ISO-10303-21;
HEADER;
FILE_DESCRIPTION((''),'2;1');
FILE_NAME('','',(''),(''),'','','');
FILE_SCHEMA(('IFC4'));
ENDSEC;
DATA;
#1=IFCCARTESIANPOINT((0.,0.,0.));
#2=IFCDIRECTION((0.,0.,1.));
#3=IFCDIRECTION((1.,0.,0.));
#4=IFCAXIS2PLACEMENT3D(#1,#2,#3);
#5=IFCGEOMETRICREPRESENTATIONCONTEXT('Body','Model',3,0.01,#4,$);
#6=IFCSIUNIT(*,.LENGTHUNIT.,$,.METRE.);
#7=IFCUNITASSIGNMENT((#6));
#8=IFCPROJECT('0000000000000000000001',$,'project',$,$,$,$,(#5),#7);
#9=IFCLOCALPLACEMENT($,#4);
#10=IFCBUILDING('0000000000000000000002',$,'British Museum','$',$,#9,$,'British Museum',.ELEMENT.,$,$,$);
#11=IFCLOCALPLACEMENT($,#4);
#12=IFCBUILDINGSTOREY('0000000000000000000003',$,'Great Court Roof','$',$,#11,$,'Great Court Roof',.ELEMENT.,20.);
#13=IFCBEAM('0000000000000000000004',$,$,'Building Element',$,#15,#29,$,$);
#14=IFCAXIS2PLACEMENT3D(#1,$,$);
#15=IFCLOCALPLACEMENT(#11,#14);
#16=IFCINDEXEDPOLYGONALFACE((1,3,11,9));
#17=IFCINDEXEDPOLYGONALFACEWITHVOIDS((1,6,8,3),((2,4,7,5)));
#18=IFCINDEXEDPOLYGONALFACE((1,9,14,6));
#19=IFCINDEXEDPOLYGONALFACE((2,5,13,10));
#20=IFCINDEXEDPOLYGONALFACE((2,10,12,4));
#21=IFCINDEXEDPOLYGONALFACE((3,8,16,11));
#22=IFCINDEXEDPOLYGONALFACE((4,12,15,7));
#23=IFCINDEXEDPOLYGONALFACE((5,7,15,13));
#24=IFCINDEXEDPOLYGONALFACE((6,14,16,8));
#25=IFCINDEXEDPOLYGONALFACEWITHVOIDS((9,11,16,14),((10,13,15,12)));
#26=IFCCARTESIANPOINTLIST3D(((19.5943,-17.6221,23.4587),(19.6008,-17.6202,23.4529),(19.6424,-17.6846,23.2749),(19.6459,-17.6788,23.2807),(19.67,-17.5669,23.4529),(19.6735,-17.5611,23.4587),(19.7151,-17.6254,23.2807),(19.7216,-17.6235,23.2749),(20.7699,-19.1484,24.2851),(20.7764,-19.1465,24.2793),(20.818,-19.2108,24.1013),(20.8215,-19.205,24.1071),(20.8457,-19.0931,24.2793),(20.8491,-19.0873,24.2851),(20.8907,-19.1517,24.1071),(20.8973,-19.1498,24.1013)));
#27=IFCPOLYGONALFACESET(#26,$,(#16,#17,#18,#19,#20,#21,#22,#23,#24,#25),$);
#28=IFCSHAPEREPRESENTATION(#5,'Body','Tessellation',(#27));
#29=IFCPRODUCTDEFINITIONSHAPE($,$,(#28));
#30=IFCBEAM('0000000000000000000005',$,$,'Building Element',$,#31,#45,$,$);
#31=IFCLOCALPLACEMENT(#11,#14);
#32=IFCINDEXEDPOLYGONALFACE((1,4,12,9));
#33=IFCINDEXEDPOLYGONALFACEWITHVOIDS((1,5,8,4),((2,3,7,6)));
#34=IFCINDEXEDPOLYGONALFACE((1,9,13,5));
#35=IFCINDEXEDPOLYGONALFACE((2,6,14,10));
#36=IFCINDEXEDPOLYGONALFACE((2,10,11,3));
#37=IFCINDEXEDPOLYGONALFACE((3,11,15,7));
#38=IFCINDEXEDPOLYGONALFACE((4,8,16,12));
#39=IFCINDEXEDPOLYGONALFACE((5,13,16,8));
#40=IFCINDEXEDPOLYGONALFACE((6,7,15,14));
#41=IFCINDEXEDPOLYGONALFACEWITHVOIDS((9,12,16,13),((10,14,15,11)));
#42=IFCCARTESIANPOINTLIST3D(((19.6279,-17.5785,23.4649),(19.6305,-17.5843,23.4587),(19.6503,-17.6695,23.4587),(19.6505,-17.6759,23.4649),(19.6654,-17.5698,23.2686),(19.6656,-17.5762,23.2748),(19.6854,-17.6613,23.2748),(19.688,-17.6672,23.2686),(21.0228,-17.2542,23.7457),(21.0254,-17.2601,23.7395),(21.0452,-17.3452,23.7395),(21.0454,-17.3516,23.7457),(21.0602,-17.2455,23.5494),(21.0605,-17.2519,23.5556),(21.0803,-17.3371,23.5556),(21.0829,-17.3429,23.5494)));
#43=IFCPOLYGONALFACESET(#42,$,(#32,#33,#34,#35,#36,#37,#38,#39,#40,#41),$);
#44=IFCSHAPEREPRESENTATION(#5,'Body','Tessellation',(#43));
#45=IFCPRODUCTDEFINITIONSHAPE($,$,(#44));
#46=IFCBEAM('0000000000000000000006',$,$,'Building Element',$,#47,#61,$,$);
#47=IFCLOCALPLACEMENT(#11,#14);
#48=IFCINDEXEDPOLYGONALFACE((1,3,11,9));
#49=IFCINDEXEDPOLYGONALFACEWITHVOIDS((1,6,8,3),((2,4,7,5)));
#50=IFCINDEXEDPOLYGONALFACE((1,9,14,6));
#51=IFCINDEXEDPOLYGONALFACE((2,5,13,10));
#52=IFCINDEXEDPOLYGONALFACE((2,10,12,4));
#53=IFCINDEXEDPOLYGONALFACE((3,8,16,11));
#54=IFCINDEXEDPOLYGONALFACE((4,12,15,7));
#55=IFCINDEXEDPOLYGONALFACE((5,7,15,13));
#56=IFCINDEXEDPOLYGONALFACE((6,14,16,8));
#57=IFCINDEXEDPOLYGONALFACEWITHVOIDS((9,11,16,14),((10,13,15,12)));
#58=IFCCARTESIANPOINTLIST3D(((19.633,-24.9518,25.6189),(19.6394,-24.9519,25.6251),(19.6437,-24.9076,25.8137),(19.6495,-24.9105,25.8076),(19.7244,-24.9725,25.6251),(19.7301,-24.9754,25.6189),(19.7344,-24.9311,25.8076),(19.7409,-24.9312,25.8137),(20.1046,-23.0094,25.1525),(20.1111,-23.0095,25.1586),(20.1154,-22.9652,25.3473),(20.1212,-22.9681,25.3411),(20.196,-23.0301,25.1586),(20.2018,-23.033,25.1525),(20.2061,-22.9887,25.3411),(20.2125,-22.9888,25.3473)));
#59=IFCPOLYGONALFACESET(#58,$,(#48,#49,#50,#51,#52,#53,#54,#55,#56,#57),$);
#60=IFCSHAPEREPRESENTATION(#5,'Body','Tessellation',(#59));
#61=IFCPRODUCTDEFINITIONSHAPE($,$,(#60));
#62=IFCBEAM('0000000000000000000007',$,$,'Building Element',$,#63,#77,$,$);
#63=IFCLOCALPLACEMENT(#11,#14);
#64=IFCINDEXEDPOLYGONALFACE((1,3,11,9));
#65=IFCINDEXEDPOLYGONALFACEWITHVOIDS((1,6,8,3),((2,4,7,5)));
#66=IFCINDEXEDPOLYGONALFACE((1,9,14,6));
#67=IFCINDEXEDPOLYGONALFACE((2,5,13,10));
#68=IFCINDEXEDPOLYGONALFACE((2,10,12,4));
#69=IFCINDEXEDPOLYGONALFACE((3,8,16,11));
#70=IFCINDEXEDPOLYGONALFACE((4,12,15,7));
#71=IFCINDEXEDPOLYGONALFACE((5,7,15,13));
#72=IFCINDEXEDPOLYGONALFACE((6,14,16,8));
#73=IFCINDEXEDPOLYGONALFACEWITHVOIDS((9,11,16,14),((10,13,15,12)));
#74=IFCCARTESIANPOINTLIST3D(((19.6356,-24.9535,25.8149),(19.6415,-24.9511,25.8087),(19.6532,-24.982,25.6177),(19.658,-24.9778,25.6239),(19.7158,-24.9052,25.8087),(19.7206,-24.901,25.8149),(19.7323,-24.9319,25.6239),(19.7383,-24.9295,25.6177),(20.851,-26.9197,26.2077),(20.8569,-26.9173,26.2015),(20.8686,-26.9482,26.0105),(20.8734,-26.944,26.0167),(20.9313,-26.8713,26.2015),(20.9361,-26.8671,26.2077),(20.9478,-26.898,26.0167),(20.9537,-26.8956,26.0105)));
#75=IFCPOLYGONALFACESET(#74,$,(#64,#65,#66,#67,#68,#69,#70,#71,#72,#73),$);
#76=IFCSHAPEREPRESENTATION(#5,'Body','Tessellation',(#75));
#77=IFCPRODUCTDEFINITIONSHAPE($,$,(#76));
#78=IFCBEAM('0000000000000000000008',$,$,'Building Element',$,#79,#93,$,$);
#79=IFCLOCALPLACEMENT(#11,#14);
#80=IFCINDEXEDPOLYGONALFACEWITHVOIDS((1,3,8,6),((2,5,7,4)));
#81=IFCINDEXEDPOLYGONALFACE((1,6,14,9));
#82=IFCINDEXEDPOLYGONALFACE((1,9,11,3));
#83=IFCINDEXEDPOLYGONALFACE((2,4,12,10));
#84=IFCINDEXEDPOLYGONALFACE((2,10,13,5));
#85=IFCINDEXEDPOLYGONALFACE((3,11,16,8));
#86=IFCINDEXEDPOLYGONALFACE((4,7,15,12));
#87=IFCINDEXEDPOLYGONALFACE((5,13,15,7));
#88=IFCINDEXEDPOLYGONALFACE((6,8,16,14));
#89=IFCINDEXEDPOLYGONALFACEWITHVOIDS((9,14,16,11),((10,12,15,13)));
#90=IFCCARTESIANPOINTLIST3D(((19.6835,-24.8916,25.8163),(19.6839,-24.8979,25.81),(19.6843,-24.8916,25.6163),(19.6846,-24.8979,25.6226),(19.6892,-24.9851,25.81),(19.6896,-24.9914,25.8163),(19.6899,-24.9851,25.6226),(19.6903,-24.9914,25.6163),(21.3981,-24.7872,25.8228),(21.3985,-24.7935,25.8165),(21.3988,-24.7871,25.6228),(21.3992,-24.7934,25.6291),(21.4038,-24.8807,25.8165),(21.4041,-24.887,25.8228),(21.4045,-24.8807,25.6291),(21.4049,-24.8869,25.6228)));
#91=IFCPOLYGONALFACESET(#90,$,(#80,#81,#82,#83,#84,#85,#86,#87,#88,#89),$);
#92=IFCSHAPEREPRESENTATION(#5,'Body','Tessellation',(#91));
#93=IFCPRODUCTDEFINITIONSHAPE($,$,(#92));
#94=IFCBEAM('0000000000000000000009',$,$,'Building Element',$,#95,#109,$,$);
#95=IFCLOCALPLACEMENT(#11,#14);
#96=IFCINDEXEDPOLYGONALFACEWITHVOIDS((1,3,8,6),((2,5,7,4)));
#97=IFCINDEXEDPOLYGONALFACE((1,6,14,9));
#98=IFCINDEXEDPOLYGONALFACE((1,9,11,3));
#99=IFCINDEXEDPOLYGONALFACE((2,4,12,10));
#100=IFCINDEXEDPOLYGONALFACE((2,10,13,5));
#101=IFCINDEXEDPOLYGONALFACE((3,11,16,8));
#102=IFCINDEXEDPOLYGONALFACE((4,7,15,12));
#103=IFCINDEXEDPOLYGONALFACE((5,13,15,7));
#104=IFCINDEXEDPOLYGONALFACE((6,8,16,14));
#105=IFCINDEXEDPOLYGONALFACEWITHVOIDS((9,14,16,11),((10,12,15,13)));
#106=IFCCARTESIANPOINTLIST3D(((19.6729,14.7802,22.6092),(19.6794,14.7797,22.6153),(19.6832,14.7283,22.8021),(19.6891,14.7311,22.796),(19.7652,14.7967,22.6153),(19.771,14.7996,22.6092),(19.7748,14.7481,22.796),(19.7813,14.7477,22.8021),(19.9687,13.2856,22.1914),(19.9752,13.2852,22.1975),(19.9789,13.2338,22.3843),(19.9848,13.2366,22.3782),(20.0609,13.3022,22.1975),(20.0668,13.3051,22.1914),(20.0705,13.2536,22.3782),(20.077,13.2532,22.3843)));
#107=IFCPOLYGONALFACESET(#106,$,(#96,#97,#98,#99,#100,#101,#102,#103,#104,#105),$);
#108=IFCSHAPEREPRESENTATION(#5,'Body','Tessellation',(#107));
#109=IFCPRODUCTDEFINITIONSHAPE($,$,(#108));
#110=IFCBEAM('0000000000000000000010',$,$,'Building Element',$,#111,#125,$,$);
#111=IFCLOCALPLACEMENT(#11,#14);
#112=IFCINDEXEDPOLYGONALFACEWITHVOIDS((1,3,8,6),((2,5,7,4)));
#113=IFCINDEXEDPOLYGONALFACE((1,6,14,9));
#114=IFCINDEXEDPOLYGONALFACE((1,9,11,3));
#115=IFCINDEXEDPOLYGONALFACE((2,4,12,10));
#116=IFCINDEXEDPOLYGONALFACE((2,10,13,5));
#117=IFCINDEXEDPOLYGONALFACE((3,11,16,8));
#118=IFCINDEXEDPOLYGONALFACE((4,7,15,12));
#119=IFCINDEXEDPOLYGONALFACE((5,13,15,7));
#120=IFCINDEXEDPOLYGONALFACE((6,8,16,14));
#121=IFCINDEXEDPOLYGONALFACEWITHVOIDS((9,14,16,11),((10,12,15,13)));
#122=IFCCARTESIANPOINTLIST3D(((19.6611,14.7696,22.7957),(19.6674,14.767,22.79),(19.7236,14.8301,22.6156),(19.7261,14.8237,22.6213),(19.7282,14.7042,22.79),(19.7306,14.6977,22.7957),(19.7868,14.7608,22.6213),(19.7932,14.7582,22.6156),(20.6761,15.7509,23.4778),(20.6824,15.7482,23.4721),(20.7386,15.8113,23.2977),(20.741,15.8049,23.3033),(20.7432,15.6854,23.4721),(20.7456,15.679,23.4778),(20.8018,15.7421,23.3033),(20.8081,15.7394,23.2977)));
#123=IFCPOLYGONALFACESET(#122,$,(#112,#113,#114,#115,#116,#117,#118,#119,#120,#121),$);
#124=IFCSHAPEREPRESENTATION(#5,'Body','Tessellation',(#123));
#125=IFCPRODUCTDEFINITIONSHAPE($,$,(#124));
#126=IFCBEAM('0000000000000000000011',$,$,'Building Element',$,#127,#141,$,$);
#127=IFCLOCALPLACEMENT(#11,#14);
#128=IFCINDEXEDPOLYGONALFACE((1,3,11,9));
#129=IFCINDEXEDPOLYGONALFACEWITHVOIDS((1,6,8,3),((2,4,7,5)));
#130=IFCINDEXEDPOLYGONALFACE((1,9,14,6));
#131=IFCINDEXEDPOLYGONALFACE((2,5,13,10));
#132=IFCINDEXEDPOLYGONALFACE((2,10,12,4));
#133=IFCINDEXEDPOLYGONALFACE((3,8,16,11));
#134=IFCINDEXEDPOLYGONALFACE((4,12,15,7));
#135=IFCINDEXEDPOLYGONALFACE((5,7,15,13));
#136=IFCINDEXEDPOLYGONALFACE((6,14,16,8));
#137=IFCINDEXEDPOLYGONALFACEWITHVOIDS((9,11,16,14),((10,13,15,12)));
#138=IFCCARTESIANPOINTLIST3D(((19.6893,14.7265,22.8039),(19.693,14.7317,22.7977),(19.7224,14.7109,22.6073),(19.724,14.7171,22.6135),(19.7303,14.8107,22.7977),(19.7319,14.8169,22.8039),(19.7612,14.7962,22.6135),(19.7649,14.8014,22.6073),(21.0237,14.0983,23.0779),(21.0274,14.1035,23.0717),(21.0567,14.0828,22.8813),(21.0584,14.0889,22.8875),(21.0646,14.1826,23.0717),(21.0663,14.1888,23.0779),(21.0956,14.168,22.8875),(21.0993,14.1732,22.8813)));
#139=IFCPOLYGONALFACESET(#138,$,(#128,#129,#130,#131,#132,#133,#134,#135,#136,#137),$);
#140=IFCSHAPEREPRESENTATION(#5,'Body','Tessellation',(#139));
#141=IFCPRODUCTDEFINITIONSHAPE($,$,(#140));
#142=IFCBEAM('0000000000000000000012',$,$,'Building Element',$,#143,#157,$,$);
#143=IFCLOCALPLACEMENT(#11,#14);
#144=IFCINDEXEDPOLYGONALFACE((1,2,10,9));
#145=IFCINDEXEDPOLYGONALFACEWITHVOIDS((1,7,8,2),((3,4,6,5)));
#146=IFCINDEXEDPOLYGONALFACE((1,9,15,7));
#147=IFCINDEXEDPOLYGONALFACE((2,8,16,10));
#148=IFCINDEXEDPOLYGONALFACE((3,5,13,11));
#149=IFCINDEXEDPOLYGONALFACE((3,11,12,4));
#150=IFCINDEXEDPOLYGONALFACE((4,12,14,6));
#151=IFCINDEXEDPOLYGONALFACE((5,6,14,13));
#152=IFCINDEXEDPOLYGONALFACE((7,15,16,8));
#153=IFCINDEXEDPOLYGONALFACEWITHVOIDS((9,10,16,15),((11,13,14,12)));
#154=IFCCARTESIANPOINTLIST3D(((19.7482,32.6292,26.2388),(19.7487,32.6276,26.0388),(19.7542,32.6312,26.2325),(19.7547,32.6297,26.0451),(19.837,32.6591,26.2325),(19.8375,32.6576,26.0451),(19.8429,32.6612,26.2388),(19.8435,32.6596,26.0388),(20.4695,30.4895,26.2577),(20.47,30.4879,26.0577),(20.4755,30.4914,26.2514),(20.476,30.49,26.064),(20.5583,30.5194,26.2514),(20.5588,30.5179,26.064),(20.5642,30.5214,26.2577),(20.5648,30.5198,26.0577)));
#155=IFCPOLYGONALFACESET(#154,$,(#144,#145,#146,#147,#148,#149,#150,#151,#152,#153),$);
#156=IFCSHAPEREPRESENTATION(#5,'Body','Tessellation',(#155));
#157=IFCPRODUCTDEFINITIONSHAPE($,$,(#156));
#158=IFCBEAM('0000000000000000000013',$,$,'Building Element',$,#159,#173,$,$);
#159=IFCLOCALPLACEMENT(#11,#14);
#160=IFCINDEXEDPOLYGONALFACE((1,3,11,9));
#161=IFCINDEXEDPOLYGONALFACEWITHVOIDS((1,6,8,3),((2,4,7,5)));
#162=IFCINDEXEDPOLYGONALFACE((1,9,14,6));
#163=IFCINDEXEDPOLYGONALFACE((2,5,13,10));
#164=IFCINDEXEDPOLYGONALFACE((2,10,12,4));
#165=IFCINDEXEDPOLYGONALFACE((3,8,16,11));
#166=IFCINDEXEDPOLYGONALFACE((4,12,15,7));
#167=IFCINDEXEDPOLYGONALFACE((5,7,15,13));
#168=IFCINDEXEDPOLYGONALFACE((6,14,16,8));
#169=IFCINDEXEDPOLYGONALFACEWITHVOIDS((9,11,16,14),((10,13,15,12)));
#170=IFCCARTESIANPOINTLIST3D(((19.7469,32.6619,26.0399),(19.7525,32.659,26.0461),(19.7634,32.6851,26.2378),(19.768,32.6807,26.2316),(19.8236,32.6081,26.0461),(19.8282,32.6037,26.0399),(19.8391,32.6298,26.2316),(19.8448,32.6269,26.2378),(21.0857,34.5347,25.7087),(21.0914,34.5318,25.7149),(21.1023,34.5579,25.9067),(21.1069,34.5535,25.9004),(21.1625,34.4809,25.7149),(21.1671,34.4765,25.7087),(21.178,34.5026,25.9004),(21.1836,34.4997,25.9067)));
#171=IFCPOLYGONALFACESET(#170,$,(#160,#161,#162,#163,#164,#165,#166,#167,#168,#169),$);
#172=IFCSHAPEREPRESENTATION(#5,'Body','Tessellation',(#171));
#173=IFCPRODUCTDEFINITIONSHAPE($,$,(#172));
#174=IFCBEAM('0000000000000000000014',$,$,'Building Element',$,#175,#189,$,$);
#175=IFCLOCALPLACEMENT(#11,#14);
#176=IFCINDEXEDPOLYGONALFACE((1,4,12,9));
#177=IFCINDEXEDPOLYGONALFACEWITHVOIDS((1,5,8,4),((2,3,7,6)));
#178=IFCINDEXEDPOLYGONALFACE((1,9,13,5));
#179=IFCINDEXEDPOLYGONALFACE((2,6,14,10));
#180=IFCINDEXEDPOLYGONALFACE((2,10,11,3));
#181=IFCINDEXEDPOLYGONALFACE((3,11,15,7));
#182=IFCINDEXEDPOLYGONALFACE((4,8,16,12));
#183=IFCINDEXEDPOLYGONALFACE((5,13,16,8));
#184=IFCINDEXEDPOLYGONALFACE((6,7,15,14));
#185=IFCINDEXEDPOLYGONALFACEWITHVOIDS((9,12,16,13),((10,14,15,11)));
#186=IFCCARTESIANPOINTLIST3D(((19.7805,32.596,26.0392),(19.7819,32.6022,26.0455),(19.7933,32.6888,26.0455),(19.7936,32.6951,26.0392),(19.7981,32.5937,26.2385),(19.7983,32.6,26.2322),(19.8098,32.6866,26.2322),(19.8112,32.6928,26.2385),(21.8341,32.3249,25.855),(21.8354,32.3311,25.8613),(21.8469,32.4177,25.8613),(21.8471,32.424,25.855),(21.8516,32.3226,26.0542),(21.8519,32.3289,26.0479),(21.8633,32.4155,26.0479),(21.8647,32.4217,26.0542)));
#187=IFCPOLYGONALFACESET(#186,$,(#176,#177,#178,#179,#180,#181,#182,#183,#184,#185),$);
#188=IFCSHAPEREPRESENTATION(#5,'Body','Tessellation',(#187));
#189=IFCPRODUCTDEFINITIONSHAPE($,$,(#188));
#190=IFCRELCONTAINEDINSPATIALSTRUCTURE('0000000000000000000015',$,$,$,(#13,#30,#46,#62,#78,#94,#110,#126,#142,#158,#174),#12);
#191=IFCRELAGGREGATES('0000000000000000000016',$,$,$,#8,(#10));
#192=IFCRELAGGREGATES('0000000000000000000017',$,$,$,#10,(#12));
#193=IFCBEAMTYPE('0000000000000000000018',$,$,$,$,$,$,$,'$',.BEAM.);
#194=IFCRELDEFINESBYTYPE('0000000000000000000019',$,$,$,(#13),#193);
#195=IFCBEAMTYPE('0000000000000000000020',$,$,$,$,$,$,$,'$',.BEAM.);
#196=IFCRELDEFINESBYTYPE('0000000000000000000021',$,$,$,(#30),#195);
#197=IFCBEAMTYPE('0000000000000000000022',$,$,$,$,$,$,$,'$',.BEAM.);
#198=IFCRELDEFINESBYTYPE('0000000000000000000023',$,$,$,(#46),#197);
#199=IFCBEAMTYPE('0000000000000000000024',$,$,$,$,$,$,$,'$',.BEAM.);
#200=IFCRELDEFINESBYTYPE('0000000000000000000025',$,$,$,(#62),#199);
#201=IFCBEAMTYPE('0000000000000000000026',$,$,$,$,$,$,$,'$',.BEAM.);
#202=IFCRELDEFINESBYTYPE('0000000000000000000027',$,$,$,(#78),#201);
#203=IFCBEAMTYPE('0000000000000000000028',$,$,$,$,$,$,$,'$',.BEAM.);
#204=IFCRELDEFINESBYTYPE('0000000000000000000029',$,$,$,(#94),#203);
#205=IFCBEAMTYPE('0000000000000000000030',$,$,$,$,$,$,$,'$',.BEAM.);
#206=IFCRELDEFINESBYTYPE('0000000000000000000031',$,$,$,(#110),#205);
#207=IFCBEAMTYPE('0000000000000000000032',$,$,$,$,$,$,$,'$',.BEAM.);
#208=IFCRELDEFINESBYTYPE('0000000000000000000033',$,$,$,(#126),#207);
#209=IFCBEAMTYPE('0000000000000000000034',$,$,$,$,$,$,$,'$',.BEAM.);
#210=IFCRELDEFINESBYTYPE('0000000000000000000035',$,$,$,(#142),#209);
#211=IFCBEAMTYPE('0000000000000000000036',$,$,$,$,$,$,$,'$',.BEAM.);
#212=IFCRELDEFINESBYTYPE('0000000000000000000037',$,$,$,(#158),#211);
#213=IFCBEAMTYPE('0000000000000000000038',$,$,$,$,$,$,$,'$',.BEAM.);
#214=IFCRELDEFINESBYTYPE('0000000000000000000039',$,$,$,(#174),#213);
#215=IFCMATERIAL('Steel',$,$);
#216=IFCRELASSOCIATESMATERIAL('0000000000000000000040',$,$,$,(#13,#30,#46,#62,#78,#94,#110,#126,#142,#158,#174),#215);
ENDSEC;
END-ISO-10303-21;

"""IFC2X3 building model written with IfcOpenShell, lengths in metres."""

from ifc_helpers import new_model, si_unit, frame, origin_with_axes, origin_2d, place, context, project, spatial, hollow_rectangle, extrude, material, type_object, element, save


model = new_model("IFC2X3")

# Units and contexts
model_context = context("Model", 3, precision=0.01, world=origin_with_axes(), identifier="Body")
ifc_project = project(units=[si_unit("LENGTHUNIT", "METRE")], contexts=[model_context])

# Building, storey
building_placement = place(None, origin_with_axes())
building = spatial("IfcBuilding", under=ifc_project, at=building_placement, Name="British Museum", Description="$", LongName="British Museum", CompositionType="ELEMENT")
storey_placement = place(None, origin_with_axes())
storey = spatial("IfcBuildingStorey", under=building, at=storey_placement, Name="Great Court Roof", Description="$", LongName="Great Court Roof", CompositionType="ELEMENT", Elevation=20.0)

# Beams
ifc_material = material(Name="Steel")
beam_type_1 = type_object("IfcBeamType", ElementType="$", PredefinedType="BEAM")
beam_1_placement = place(None, origin_with_axes())
element("IfcBeam", 1, at=beam_1_placement, inside=storey, type_object=beam_type_1, material=ifc_material, Description="Building Element", context=model_context, shape_type="SweptSolid", body=[
    extrude(hollow_rectangle(XDim=0.1, YDim=0.2, WallThickness=0.0063, InnerFilletRadius=-0.0063, OuterFilletRadius=0.0, at=origin_2d()), frame((19.658, -17.6228, 23.3668), z_axis=(0.560807, -0.728067, 0.394226), x_axis=(0.792226, 0.610227, 0.0)), (0.0, 0.0, 1.0), 2.0963),
])
beam_type_2 = type_object("IfcBeamType", ElementType="$", PredefinedType="BEAM")
beam_2_placement = place(None, origin_with_axes())
element("IfcBeam", 2, at=beam_2_placement, inside=storey, type_object=beam_type_2, material=ifc_material, Description="Building Element", context=model_context, shape_type="SweptSolid", body=[
    extrude(hollow_rectangle(XDim=0.1, YDim=0.2, WallThickness=0.0063, InnerFilletRadius=-0.0063, OuterFilletRadius=0.0, at=origin_2d()), frame((19.658, -17.6228, 23.3668), z_axis=(0.955827, 0.222199, 0.192415), x_axis=(-0.22643, 0.974027, 0.0)), (0.0, 0.0, 1.0), 1.4593),
])
beam_type_3 = type_object("IfcBeamType", ElementType="$", PredefinedType="BEAM")
beam_3_placement = place(None, origin_with_axes())
element("IfcBeam", 3, at=beam_3_placement, inside=storey, type_object=beam_type_3, material=ifc_material, Description="Building Element", context=model_context, shape_type="SweptSolid", body=[
    extrude(hollow_rectangle(XDim=0.1, YDim=0.2, WallThickness=0.0063, InnerFilletRadius=-0.0063, OuterFilletRadius=0.0, at=origin_2d()), frame((19.6869, -24.9415, 25.7163), z_axis=(0.229798, 0.946337, -0.227243), x_axis=(-0.97176, 0.235972, 0.0)), (0.0, 0.0, 1.0), 2.0525),
])
beam_type_4 = type_object("IfcBeamType", ElementType="$", PredefinedType="BEAM")
beam_4_placement = place(None, origin_with_axes())
element("IfcBeam", 4, at=beam_4_placement, inside=storey, type_object=beam_type_4, material=ifc_material, Description="Building Element", context=model_context, shape_type="SweptSolid", body=[
    extrude(hollow_rectangle(XDim=0.1, YDim=0.2, WallThickness=0.0063, InnerFilletRadius=-0.0063, OuterFilletRadius=0.0, at=origin_2d()), frame((19.6869, -24.9415, 25.7163), z_axis=(0.518386, -0.838578, 0.167521), x_axis=(0.850598, 0.525817, 0.0)), (0.0, 0.0, 1.0), 2.3446),
])
beam_type_5 = type_object("IfcBeamType", ElementType="$", PredefinedType="BEAM")
beam_5_placement = place(None, origin_with_axes())
element("IfcBeam", 5, at=beam_5_placement, inside=storey, type_object=beam_type_5, material=ifc_material, Description="Building Element", context=model_context, shape_type="SweptSolid", body=[
    extrude(hollow_rectangle(XDim=0.1, YDim=0.2, WallThickness=0.0063, InnerFilletRadius=-0.0063, OuterFilletRadius=0.0, at=origin_2d()), frame((19.6869, -24.9415, 25.7163), z_axis=(0.998143, 0.060798, 0.003797), x_axis=(-0.060798, 0.99815, 0.0)), (0.0, 0.0, 1.0), 1.7177),
])
beam_type_6 = type_object("IfcBeamType", ElementType="$", PredefinedType="BEAM")
beam_6_placement = place(None, origin_with_axes())
element("IfcBeam", 6, at=beam_6_placement, inside=storey, type_object=beam_type_6, material=ifc_material, Description="Building Element", context=model_context, shape_type="SweptSolid", body=[
    extrude(hollow_rectangle(XDim=0.1, YDim=0.2, WallThickness=0.0063, InnerFilletRadius=-0.0063, OuterFilletRadius=0.0, at=origin_2d()), frame((19.7271, 14.7639, 22.7056), z_axis=(0.187192, -0.946054, -0.264465), x_axis=(0.980981, 0.194102, 0.0)), (0.0, 0.0, 1.0), 1.5797),
])
beam_type_7 = type_object("IfcBeamType", ElementType="$", PredefinedType="BEAM")
beam_7_placement = place(None, origin_with_axes())
element("IfcBeam", 7, at=beam_7_placement, inside=storey, type_object=beam_type_7, material=ifc_material, Description="Building Element", context=model_context, shape_type="SweptSolid", body=[
    extrude(hollow_rectangle(XDim=0.1, YDim=0.2, WallThickness=0.0063, InnerFilletRadius=-0.0063, OuterFilletRadius=0.0, at=origin_2d()), frame((19.7271, 14.7639, 22.7056), z_axis=(0.647359, 0.625837, 0.435035), x_axis=(-0.695055, 0.718957, 0.0)), (0.0, 0.0, 1.0), 1.5679),
])
beam_type_8 = type_object("IfcBeamType", ElementType="$", PredefinedType="BEAM")
beam_8_placement = place(None, origin_with_axes())
element("IfcBeam", 8, at=beam_8_placement, inside=storey, type_object=beam_type_8, material=ifc_material, Description="Building Element", context=model_context, shape_type="SweptSolid", body=[
    extrude(hollow_rectangle(XDim=0.1, YDim=0.2, WallThickness=0.0063, InnerFilletRadius=-0.0063, OuterFilletRadius=0.0, at=origin_2d()), frame((19.7271, 14.7639, 22.7056), z_axis=(0.889548, -0.418739, 0.18265), x_axis=(0.425904, 0.904769, 0.0)), (0.0, 0.0, 1.0), 1.5001),
])
beam_type_9 = type_object("IfcBeamType", ElementType="$", PredefinedType="BEAM")
beam_9_placement = place(None, origin_with_axes())
element("IfcBeam", 9, at=beam_9_placement, inside=storey, type_object=beam_type_9, material=ifc_material, Description="Building Element", context=model_context, shape_type="SweptSolid", body=[
    extrude(hollow_rectangle(XDim=0.1, YDim=0.2, WallThickness=0.0063, InnerFilletRadius=-0.0063, OuterFilletRadius=0.0, at=origin_2d()), frame((19.7958, 32.6444, 26.1388), z_axis=(0.319423, -0.947575, 0.008343), x_axis=(0.947608, 0.319434, 0.0)), (0.0, 0.0, 1.0), 2.2581),
])
beam_type_10 = type_object("IfcBeamType", ElementType="$", PredefinedType="BEAM")
beam_10_placement = place(None, origin_with_axes())
element("IfcBeam", 10, at=beam_10_placement, inside=storey, type_object=beam_type_10, material=ifc_material, Description="Building Element", context=model_context, shape_type="SweptSolid", body=[
    extrude(hollow_rectangle(XDim=0.1, YDim=0.2, WallThickness=0.0063, InnerFilletRadius=-0.0063, OuterFilletRadius=0.0, at=origin_2d()), frame((19.7958, 32.6444, 26.1388), z_axis=(0.575641, 0.80521, -0.142387), x_axis=(-0.813498, 0.581567, 0.0)), (0.0, 0.0, 1.0), 2.3259),
])
beam_type_11 = type_object("IfcBeamType", ElementType="$", PredefinedType="BEAM")
beam_11_placement = place(None, origin_with_axes())
element("IfcBeam", 11, at=beam_11_placement, inside=storey, type_object=beam_type_11, material=ifc_material, Description="Building Element", context=model_context, shape_type="SweptSolid", body=[
    extrude(hollow_rectangle(XDim=0.1, YDim=0.2, WallThickness=0.0063, InnerFilletRadius=-0.0063, OuterFilletRadius=0.0, at=origin_2d()), frame((19.7958, 32.6444, 26.1388), z_axis=(0.9875, -0.130361, -0.088595), x_axis=(0.130876, 0.991399, 0.0)), (0.0, 0.0, 1.0), 2.0795),
])

save(model, "model.ifc")
